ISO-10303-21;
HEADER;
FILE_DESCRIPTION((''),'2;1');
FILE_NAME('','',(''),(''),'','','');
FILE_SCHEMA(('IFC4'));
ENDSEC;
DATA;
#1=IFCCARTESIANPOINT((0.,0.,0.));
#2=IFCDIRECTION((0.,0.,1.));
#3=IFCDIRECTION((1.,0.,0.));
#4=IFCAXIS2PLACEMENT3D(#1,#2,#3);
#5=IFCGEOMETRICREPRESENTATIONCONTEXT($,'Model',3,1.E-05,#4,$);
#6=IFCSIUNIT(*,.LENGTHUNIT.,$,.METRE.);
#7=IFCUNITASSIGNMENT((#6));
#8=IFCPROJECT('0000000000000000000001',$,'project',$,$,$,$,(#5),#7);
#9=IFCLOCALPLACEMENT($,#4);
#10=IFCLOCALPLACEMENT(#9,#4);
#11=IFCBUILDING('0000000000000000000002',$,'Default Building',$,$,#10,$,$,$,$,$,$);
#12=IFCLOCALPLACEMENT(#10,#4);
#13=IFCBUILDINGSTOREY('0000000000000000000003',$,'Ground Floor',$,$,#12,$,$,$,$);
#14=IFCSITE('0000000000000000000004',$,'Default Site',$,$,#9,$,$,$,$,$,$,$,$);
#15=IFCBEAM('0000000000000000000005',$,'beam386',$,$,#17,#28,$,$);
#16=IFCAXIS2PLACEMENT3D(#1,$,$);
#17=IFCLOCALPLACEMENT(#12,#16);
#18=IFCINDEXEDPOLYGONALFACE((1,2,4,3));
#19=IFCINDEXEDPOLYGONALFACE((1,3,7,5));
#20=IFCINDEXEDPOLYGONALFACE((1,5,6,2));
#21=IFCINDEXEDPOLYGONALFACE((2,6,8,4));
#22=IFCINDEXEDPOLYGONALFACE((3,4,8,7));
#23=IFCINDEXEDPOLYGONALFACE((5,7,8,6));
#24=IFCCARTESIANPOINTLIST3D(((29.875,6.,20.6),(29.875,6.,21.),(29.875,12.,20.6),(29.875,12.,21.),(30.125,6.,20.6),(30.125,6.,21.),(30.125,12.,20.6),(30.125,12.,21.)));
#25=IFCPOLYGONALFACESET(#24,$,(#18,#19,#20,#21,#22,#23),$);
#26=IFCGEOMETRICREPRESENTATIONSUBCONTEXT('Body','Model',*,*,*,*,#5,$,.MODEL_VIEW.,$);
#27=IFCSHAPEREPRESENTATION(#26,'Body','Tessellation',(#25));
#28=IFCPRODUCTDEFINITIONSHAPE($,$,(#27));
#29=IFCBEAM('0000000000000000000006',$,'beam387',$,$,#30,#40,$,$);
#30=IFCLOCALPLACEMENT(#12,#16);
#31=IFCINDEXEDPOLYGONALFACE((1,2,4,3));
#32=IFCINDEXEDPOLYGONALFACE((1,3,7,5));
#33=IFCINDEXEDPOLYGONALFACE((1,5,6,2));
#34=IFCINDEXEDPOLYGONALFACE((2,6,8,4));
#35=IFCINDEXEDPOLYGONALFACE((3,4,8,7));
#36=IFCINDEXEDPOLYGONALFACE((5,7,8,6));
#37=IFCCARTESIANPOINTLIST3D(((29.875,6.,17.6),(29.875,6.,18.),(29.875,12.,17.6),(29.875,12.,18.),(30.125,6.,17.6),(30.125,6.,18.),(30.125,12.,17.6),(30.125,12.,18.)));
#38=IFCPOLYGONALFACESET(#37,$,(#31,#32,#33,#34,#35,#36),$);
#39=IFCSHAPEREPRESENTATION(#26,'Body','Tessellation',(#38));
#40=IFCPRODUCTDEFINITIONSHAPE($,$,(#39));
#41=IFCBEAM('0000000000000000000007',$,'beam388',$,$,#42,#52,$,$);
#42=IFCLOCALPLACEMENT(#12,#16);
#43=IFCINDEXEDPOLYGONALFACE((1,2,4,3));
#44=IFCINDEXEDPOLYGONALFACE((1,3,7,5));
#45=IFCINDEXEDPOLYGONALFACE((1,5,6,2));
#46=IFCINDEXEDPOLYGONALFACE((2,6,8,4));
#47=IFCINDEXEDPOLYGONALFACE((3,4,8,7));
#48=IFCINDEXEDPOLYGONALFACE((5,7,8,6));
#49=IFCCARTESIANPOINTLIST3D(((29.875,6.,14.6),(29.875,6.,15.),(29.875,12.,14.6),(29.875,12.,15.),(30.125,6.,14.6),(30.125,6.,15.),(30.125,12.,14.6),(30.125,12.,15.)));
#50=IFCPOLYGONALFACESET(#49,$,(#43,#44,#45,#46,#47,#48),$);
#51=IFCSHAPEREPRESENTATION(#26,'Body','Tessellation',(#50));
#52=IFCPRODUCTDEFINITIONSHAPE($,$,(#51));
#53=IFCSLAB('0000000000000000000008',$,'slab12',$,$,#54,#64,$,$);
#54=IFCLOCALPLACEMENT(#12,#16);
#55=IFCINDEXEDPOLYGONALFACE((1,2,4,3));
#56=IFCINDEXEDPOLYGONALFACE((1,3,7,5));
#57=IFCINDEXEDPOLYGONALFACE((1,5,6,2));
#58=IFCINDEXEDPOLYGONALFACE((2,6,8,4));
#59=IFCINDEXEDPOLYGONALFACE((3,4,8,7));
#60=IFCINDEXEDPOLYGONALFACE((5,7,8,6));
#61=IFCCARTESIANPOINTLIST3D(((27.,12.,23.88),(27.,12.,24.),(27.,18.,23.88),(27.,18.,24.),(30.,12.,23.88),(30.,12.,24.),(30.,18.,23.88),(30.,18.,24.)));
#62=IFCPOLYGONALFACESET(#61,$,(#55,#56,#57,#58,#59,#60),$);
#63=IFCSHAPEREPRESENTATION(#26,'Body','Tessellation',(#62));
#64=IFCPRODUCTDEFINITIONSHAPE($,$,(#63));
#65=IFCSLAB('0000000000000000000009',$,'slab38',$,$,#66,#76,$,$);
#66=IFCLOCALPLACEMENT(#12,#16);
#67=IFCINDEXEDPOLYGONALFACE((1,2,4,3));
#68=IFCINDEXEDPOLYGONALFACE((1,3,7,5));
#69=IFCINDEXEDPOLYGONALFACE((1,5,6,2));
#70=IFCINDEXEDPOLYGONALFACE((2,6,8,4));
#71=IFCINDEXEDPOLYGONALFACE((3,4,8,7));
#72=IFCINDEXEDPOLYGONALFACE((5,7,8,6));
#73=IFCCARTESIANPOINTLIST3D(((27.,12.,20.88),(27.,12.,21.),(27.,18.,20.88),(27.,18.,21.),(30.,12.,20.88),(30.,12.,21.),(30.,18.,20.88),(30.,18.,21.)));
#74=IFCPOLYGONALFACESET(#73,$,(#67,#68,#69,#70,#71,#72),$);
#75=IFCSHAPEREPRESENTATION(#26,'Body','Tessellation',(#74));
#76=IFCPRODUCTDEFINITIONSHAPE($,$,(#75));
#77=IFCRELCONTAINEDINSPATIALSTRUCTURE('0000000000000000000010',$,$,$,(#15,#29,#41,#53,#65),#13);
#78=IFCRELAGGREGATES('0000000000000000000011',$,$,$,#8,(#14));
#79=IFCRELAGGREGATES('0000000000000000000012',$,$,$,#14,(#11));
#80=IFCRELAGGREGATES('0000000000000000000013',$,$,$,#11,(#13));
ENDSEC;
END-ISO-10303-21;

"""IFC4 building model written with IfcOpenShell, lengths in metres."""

from ifc_helpers import new_model, si_unit, frame, origin_with_axes, place, context, subcontext, project, spatial, indexed_curve, outline, extrude, element, save


model = new_model("IFC4")

# Units and contexts
model_context = context("Model", 3, precision=1e-05, world=origin_with_axes())
body_context = subcontext(model_context, "Body", "Model", "MODEL_VIEW")
ifc_project = project(units=[si_unit("LENGTHUNIT", "METRE")], contexts=[model_context])

# Site, building, storey
site_placement = place(None, origin_with_axes())
site = spatial("IfcSite", under=ifc_project, at=site_placement, Name="Default Site")
building_placement = place(site_placement, origin_with_axes())
building = spatial("IfcBuilding", under=site, at=building_placement, Name="Default Building")
storey_placement = place(building_placement, origin_with_axes())
storey = spatial("IfcBuildingStorey", under=building, at=storey_placement, Name="Ground Floor")

# Beams
for number, where, z_axis, x_axis, name in (
    (1, (29.875, 12.0, 20.6), (0.0, 0.0, 1.0), (0.0, -1.0, 0.0), "beam386"),
    (2, (29.875, 12.0, 17.6), (0.0, 0.0, 1.0), (0.0, -1.0, 0.0), "beam387"),
    (3, (29.875, 12.0, 14.6), (0.0, 0.0, 1.0), (0.0, -1.0, 0.0), "beam388"),
):
    element("IfcBeam", number, at=place(storey_placement, frame(where, z_axis=z_axis, x_axis=x_axis)), inside=storey, Name=name, context=body_context, shape_type="SweptSolid", body=[
        extrude(outline(indexed_curve([(0.0, 0.0), (0.0, 0.25), (6.0, 0.25), (6.0, 0.0), (0.0, 0.0)], self_intersect=False)), origin_with_axes(), (0.0, 0.0, 1.0), 0.4),
    ])

# Slabs
for number, where, z_axis, x_axis, name in (
    (4, (27.0, 12.0, 23.88), (0.0, 0.0, 1.0), (1.0, 0.0, 0.0), "slab12"),
    (5, (27.0, 12.0, 20.88), (0.0, 0.0, 1.0), (1.0, 0.0, 0.0), "slab38"),
):
    element("IfcSlab", number, at=place(storey_placement, frame(where, z_axis=z_axis, x_axis=x_axis)), inside=storey, Name=name, context=body_context, shape_type="SweptSolid", body=[
        extrude(outline(indexed_curve([(0.0, 0.0), (0.0, 6.0), (3.0, 6.0), (3.0, 0.0), (0.0, 0.0)], self_intersect=False)), origin_with_axes(), (0.0, 0.0, 1.0), 0.12),
    ])

save(model, "model.ifc")
